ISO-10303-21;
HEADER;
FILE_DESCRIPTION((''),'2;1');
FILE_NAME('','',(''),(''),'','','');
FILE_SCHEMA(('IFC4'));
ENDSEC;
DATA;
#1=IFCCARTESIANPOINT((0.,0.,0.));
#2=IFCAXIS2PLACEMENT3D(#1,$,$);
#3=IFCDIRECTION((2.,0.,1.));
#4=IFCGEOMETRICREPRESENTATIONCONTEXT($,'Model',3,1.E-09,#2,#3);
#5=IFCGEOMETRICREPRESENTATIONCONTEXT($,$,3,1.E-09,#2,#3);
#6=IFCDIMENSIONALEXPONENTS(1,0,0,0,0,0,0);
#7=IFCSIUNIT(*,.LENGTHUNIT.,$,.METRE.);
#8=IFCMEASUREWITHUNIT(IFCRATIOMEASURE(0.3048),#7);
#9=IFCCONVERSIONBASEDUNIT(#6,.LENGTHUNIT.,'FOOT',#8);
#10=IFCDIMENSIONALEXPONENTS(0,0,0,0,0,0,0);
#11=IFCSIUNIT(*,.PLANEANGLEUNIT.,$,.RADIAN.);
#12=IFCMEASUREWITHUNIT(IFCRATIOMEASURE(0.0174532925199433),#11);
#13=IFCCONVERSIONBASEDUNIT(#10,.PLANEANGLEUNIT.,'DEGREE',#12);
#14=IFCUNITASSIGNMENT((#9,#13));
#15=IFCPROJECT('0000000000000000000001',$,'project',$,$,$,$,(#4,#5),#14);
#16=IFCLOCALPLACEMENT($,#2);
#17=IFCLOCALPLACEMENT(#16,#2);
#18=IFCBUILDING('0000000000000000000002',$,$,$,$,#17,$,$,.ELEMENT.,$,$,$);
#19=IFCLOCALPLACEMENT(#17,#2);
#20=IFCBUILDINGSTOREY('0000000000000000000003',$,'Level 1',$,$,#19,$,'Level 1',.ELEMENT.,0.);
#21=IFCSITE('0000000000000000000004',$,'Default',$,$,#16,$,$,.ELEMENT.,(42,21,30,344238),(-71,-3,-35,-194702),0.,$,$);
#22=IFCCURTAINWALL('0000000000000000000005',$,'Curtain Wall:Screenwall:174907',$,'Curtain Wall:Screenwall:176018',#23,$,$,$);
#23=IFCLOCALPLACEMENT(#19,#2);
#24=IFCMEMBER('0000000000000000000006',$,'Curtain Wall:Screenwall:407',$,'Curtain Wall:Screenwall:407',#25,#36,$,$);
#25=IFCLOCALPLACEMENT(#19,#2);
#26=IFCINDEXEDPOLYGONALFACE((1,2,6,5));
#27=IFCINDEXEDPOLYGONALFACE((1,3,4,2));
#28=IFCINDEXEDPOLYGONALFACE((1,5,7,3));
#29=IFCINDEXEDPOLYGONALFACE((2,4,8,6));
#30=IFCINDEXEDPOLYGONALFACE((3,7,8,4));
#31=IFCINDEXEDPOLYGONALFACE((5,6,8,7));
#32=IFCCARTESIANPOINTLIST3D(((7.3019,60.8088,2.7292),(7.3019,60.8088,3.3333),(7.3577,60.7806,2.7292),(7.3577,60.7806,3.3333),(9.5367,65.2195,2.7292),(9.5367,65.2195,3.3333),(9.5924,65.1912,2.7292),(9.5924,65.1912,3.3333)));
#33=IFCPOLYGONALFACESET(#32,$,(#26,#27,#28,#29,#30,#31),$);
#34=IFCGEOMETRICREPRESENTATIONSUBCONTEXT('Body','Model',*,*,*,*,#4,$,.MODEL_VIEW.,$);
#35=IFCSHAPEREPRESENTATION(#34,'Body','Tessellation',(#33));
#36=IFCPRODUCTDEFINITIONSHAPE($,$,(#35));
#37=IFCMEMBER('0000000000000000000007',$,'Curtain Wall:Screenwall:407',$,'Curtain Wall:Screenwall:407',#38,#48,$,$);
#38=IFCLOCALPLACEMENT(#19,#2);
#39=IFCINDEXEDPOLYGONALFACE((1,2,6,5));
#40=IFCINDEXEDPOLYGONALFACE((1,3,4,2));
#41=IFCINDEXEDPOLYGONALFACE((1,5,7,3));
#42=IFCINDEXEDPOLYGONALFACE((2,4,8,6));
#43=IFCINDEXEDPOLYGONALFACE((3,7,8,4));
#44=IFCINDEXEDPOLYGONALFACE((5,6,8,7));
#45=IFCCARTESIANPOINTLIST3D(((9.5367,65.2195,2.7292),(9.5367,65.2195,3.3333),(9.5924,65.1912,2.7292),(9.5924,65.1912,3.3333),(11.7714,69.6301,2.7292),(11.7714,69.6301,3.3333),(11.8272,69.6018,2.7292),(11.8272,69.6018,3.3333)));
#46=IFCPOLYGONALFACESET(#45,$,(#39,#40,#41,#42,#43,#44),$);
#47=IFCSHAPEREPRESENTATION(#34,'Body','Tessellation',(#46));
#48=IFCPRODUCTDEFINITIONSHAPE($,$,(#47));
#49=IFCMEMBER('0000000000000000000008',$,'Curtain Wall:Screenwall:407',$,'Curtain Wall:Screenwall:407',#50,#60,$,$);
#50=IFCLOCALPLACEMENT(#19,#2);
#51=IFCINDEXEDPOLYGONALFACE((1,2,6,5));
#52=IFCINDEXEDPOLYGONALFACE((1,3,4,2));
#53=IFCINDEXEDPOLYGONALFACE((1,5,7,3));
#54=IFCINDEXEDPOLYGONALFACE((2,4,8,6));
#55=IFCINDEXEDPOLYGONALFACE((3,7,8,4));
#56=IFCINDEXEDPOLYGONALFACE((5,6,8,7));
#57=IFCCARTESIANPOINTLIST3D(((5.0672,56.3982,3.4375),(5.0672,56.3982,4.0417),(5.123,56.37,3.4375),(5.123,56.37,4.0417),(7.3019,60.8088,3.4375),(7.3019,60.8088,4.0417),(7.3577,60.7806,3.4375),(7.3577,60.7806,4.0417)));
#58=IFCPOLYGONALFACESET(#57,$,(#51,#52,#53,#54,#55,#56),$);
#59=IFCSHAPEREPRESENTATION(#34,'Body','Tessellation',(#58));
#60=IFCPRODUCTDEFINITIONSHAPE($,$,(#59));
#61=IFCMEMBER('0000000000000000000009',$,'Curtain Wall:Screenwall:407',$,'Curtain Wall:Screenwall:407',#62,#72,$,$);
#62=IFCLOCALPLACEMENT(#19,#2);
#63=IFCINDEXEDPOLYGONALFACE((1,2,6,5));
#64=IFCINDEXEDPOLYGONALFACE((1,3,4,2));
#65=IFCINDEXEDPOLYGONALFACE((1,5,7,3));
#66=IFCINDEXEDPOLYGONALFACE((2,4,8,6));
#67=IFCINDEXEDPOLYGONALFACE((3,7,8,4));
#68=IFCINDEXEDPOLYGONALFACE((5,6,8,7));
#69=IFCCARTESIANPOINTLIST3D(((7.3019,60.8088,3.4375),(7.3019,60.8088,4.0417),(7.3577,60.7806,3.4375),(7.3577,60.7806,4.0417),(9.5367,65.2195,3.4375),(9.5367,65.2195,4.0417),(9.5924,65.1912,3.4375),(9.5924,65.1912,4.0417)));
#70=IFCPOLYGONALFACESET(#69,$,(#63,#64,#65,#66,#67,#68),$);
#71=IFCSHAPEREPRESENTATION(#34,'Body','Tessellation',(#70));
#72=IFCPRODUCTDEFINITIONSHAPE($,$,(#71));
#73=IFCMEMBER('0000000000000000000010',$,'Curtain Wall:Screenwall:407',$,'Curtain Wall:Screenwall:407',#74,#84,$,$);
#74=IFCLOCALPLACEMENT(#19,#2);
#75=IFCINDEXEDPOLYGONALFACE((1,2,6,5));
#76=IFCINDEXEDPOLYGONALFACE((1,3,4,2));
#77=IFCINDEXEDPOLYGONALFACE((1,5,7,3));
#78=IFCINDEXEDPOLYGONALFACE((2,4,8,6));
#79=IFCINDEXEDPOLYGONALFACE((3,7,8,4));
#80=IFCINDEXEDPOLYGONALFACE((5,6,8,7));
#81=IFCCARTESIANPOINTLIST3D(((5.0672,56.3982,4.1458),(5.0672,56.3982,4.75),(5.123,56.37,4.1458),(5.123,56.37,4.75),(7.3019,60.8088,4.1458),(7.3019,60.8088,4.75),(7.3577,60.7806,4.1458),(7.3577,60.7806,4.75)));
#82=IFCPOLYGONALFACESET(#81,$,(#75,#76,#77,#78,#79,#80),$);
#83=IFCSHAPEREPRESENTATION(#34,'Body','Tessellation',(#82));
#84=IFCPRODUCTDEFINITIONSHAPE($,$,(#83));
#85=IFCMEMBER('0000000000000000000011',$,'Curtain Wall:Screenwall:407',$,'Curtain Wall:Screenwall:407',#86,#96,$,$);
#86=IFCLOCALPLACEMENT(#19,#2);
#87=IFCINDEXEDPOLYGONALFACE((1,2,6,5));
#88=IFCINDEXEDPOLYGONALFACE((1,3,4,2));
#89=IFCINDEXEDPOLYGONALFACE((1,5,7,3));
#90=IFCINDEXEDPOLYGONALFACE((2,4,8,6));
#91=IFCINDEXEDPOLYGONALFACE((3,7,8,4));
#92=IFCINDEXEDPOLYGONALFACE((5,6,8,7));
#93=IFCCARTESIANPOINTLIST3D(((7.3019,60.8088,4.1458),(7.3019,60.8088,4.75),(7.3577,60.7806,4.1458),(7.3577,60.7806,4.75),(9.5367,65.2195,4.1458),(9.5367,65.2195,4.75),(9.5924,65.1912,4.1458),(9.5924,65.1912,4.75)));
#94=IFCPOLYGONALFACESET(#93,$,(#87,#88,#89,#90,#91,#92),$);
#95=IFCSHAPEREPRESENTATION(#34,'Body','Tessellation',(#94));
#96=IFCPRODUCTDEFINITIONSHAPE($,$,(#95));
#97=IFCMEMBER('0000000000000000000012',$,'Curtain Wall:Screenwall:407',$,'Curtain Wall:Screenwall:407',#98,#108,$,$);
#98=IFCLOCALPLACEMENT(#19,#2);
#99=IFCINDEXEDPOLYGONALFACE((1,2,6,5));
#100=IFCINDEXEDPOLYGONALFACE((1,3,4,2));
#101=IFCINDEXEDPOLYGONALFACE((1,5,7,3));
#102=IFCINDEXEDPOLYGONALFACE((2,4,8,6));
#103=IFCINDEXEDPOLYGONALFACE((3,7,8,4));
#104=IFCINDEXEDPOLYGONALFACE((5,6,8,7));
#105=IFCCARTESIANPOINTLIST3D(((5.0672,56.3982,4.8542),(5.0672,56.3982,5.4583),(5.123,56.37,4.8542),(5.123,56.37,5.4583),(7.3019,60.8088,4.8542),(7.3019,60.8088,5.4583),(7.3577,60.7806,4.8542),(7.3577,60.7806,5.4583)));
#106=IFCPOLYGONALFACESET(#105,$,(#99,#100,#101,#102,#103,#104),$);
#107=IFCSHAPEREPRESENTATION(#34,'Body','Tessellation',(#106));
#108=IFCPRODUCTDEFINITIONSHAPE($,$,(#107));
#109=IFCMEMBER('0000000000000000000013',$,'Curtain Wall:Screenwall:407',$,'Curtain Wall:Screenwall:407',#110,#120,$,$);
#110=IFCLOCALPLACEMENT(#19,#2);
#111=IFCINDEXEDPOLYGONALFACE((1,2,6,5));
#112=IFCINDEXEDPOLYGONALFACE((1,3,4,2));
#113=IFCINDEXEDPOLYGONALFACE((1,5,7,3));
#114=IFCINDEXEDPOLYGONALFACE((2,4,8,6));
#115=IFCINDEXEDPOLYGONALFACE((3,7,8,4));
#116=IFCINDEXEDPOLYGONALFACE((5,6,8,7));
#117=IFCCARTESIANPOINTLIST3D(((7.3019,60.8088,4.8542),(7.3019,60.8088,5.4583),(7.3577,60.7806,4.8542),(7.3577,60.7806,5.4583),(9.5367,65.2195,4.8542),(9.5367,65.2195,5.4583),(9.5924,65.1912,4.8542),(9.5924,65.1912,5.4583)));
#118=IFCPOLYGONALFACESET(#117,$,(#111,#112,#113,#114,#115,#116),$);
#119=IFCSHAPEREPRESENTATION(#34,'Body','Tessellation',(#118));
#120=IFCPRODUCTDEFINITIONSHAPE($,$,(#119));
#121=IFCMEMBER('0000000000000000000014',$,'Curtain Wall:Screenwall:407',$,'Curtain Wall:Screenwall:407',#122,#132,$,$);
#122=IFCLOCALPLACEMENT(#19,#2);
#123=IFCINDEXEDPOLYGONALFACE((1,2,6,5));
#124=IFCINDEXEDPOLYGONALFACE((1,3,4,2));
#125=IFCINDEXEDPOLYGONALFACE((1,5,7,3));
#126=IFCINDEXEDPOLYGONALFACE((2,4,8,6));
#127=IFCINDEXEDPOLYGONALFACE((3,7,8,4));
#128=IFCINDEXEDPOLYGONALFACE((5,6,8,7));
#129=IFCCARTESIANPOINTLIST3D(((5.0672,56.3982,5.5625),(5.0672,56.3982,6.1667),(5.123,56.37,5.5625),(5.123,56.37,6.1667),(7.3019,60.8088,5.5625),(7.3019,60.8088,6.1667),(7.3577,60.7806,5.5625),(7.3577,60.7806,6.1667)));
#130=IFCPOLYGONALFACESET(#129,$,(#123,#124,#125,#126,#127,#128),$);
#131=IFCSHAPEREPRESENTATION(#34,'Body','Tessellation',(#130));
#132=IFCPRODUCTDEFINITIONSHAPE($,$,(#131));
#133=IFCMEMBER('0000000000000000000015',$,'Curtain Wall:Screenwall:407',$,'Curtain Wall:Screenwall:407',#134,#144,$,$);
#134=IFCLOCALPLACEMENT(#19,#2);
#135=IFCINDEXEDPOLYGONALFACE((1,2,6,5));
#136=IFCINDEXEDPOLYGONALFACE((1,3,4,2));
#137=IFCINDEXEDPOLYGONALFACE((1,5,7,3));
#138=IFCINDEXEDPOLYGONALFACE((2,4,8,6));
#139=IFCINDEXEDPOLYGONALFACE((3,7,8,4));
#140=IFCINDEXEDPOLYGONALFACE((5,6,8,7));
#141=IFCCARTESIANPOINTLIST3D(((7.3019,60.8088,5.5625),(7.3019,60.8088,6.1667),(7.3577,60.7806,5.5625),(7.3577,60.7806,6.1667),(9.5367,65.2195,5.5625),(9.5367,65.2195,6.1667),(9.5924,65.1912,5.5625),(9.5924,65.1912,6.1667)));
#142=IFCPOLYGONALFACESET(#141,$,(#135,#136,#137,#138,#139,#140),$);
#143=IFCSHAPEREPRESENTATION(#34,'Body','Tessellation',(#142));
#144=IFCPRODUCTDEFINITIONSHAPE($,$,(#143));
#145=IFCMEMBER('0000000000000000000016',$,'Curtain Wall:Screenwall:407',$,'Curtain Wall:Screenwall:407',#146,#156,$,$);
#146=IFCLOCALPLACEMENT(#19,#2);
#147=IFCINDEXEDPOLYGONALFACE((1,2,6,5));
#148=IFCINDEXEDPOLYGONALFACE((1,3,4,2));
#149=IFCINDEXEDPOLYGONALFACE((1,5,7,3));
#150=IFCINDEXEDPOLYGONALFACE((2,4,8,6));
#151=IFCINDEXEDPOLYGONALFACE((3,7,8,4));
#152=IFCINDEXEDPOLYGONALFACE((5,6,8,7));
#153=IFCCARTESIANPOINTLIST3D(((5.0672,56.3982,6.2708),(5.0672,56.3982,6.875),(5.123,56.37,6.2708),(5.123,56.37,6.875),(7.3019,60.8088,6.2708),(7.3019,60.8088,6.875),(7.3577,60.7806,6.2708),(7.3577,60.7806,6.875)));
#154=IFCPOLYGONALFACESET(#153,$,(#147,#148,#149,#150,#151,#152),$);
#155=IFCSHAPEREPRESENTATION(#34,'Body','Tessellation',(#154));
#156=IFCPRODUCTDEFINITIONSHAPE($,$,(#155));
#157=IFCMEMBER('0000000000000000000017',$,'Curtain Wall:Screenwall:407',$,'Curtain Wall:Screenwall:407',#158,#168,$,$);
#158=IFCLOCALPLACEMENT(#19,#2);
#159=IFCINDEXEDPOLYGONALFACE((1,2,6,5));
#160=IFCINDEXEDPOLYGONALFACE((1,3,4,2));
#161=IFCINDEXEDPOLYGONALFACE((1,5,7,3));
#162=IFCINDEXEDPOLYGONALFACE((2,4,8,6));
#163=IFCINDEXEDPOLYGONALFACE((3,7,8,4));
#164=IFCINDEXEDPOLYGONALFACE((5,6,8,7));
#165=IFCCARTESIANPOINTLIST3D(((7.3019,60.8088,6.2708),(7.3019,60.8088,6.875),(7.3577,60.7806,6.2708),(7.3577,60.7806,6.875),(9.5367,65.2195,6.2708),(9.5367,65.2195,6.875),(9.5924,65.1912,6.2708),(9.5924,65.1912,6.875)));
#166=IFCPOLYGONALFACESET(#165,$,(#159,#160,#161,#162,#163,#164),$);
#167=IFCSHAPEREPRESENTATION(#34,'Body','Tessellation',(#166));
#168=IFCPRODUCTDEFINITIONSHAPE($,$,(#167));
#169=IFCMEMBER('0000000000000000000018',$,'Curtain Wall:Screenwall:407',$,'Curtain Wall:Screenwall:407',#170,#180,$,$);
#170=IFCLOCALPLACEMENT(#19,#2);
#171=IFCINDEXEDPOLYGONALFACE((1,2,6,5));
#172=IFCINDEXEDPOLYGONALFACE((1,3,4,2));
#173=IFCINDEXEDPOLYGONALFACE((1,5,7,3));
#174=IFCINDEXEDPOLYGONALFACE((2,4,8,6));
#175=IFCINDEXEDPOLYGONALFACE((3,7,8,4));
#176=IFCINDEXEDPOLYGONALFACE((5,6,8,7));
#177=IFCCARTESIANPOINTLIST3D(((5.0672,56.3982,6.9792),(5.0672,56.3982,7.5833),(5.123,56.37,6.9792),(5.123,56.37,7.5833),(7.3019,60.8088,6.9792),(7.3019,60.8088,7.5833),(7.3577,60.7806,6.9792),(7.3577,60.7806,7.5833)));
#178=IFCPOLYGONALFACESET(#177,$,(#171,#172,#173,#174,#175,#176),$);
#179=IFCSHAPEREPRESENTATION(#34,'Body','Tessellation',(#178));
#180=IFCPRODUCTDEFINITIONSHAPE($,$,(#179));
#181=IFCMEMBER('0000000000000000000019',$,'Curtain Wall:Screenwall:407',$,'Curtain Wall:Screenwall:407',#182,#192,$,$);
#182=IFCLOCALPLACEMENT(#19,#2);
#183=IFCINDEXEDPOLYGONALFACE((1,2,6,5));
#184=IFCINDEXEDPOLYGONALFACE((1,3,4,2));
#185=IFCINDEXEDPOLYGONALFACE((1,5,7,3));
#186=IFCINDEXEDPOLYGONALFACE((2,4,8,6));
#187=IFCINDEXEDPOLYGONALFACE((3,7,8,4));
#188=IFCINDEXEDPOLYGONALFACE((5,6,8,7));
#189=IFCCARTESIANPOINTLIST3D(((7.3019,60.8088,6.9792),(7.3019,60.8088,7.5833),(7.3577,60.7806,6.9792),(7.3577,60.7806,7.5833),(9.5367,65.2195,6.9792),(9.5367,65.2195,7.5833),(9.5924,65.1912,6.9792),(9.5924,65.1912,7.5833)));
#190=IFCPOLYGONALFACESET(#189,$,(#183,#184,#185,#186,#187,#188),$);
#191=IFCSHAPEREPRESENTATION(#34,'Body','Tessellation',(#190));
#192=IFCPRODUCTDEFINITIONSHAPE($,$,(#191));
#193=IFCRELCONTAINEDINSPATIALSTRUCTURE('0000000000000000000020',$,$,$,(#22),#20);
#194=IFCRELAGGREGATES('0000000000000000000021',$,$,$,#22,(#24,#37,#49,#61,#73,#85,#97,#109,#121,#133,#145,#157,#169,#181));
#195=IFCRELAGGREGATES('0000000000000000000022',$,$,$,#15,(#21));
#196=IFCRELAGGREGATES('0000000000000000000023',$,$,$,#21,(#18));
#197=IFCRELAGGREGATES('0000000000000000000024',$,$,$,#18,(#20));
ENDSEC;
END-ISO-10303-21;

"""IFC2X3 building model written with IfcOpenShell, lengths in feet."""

from ifc_helpers import new_model, entity, si_unit, converted_unit, direction, frame, frame_2d, origin, place, context, subcontext, project, spatial, rectangle, extrude, element, aggregate, save


model = new_model("IFC2X3")

# Units and contexts
model_context = context("Model", 3, precision=1e-09, world=origin(), true_north=direction((2.0, 0.0, 1.0)))
context_of_model = context(None, 3, precision=1e-09, world=origin(), true_north=direction((2.0, 0.0, 1.0)))
body_context = subcontext(model_context, "Body", "Model", "MODEL_VIEW")
ifc_project = project(units=[converted_unit("LENGTHUNIT", "FOOT", entity("IfcRatioMeasure", 0.3048), si_unit("LENGTHUNIT", "METRE"), dimensions=[1, 0, 0, 0, 0, 0, 0]), converted_unit("PLANEANGLEUNIT", "DEGREE", entity("IfcRatioMeasure", 0.0174532925199433), si_unit("PLANEANGLEUNIT", "RADIAN"), dimensions=[0, 0, 0, 0, 0, 0, 0])], contexts=[model_context, context_of_model])

# Site, building, storey
site_placement = place(None, origin())
site = spatial("IfcSite", under=ifc_project, at=site_placement, Name="Default", CompositionType="ELEMENT", RefLatitude=(42, 21, 30, 344238), RefLongitude=(-71, -3, -35, -194702), RefElevation=0.0)
building_placement = place(site_placement, origin())
building = spatial("IfcBuilding", under=site, at=building_placement, CompositionType="ELEMENT")
storey_placement = place(building_placement, origin())
storey = spatial("IfcBuildingStorey", under=building, at=storey_placement, Name="Level 1", LongName="Level 1", CompositionType="ELEMENT", Elevation=0.0)

# Curtain wall, members
curtain_wall_placement = place(storey_placement, origin())
curtain_wall = element("IfcCurtainWall", 1, at=curtain_wall_placement, inside=storey, Name="Curtain Wall:Screenwall:174907", ObjectType="Curtain Wall:Screenwall:176018")
member_1_placement = place(curtain_wall_placement, frame((7.3019, 60.7806, 2.7292)))
member_1 = element("IfcMember", 2, at=member_1_placement, Name="Curtain Wall:Screenwall:407", ObjectType="Curtain Wall:Screenwall:407", context=body_context, shape_type="SweptSolid", body=[
    extrude(rectangle(XDim=4.9444, YDim=0.0625, at=frame_2d((0.0, 0.0), x_axis=(1.0, 0.0))), frame((1.1452, 2.2194, 0.0), z_axis=(0.0, 0.0, 1.0), x_axis=(-0.451968, -0.892034, 0.0)), (0.0, 0.0, 1.0), 0.6042),
])
member_2_placement = place(curtain_wall_placement, frame((9.5367, 65.1912, 2.7292)))
member_2 = element("IfcMember", 3, at=member_2_placement, Name="Curtain Wall:Screenwall:407", ObjectType="Curtain Wall:Screenwall:407", context=body_context, shape_type="SweptSolid", body=[
    extrude(rectangle(XDim=4.9444, YDim=0.0625, at=frame_2d((0.0, 0.0), x_axis=(1.0, 0.0))), frame((1.1452, 2.2194, 0.0), z_axis=(0.0, 0.0, 1.0), x_axis=(-0.451968, -0.892034, 0.0)), (0.0, 0.0, 1.0), 0.6042),
])
member_3_placement = place(curtain_wall_placement, frame((5.0672, 56.37, 3.4375)))
member_3 = element("IfcMember", 4, at=member_3_placement, Name="Curtain Wall:Screenwall:407", ObjectType="Curtain Wall:Screenwall:407", context=body_context, shape_type="SweptSolid", body=[
    extrude(rectangle(XDim=4.9444, YDim=0.0625, at=frame_2d((0.0, 0.0), x_axis=(1.0, 0.0))), frame((1.1452, 2.2194, 0.0), z_axis=(0.0, 0.0, 1.0), x_axis=(-0.451968, -0.892034, 0.0)), (0.0, 0.0, 1.0), 0.6042),
])
member_4_placement = place(curtain_wall_placement, frame((7.3019, 60.7806, 3.4375)))
member_4 = element("IfcMember", 5, at=member_4_placement, Name="Curtain Wall:Screenwall:407", ObjectType="Curtain Wall:Screenwall:407", context=body_context, shape_type="SweptSolid", body=[
    extrude(rectangle(XDim=4.9444, YDim=0.0625, at=frame_2d((0.0, 0.0), x_axis=(1.0, 0.0))), frame((1.1452, 2.2194, 0.0), z_axis=(0.0, 0.0, 1.0), x_axis=(-0.451968, -0.892034, 0.0)), (0.0, 0.0, 1.0), 0.6042),
])
member_5_placement = place(curtain_wall_placement, frame((5.0672, 56.37, 4.1458)))
member_5 = element("IfcMember", 6, at=member_5_placement, Name="Curtain Wall:Screenwall:407", ObjectType="Curtain Wall:Screenwall:407", context=body_context, shape_type="SweptSolid", body=[
    extrude(rectangle(XDim=4.9444, YDim=0.0625, at=frame_2d((0.0, 0.0), x_axis=(1.0, 0.0))), frame((1.1452, 2.2194, 0.0), z_axis=(0.0, 0.0, 1.0), x_axis=(-0.451968, -0.892034, 0.0)), (0.0, 0.0, 1.0), 0.6042),
])
member_6_placement = place(curtain_wall_placement, frame((7.3019, 60.7806, 4.1458)))
member_6 = element("IfcMember", 7, at=member_6_placement, Name="Curtain Wall:Screenwall:407", ObjectType="Curtain Wall:Screenwall:407", context=body_context, shape_type="SweptSolid", body=[
    extrude(rectangle(XDim=4.9444, YDim=0.0625, at=frame_2d((0.0, 0.0), x_axis=(1.0, 0.0))), frame((1.1452, 2.2194, 0.0), z_axis=(0.0, 0.0, 1.0), x_axis=(-0.451968, -0.892034, 0.0)), (0.0, 0.0, 1.0), 0.6042),
])
member_7_placement = place(curtain_wall_placement, frame((5.0672, 56.37, 4.8542)))
member_7 = element("IfcMember", 8, at=member_7_placement, Name="Curtain Wall:Screenwall:407", ObjectType="Curtain Wall:Screenwall:407", context=body_context, shape_type="SweptSolid", body=[
    extrude(rectangle(XDim=4.9444, YDim=0.0625, at=frame_2d((0.0, 0.0), x_axis=(1.0, 0.0))), frame((1.1452, 2.2194, 0.0), z_axis=(0.0, 0.0, 1.0), x_axis=(-0.451968, -0.892034, 0.0)), (0.0, 0.0, 1.0), 0.6042),
])
member_8_placement = place(curtain_wall_placement, frame((7.3019, 60.7806, 4.8542)))
member_8 = element("IfcMember", 9, at=member_8_placement, Name="Curtain Wall:Screenwall:407", ObjectType="Curtain Wall:Screenwall:407", context=body_context, shape_type="SweptSolid", body=[
    extrude(rectangle(XDim=4.9444, YDim=0.0625, at=frame_2d((0.0, 0.0), x_axis=(1.0, 0.0))), frame((1.1452, 2.2194, 0.0), z_axis=(0.0, 0.0, 1.0), x_axis=(-0.451968, -0.892034, 0.0)), (0.0, 0.0, 1.0), 0.6042),
])
member_9_placement = place(curtain_wall_placement, frame((5.0672, 56.37, 5.5625)))
member_9 = element("IfcMember", 10, at=member_9_placement, Name="Curtain Wall:Screenwall:407", ObjectType="Curtain Wall:Screenwall:407", context=body_context, shape_type="SweptSolid", body=[
    extrude(rectangle(XDim=4.9444, YDim=0.0625, at=frame_2d((0.0, 0.0), x_axis=(1.0, 0.0))), frame((1.1452, 2.2194, 0.0), z_axis=(0.0, 0.0, 1.0), x_axis=(-0.451968, -0.892034, 0.0)), (0.0, 0.0, 1.0), 0.6042),
])
member_10_placement = place(curtain_wall_placement, frame((7.3019, 60.7806, 5.5625)))
member_10 = element("IfcMember", 11, at=member_10_placement, Name="Curtain Wall:Screenwall:407", ObjectType="Curtain Wall:Screenwall:407", context=body_context, shape_type="SweptSolid", body=[
    extrude(rectangle(XDim=4.9444, YDim=0.0625, at=frame_2d((0.0, 0.0), x_axis=(1.0, 0.0))), frame((1.1452, 2.2194, 0.0), z_axis=(0.0, 0.0, 1.0), x_axis=(-0.451968, -0.892034, 0.0)), (0.0, 0.0, 1.0), 0.6042),
])
member_11_placement = place(curtain_wall_placement, frame((5.0672, 56.37, 6.2708)))
member_11 = element("IfcMember", 12, at=member_11_placement, Name="Curtain Wall:Screenwall:407", ObjectType="Curtain Wall:Screenwall:407", context=body_context, shape_type="SweptSolid", body=[
    extrude(rectangle(XDim=4.9444, YDim=0.0625, at=frame_2d((0.0, 0.0), x_axis=(1.0, 0.0))), frame((1.1452, 2.2194, 0.0), z_axis=(0.0, 0.0, 1.0), x_axis=(-0.451968, -0.892034, 0.0)), (0.0, 0.0, 1.0), 0.6042),
])
member_12_placement = place(curtain_wall_placement, frame((7.3019, 60.7806, 6.2708)))
member_12 = element("IfcMember", 13, at=member_12_placement, Name="Curtain Wall:Screenwall:407", ObjectType="Curtain Wall:Screenwall:407", context=body_context, shape_type="SweptSolid", body=[
    extrude(rectangle(XDim=4.9444, YDim=0.0625, at=frame_2d((0.0, 0.0), x_axis=(1.0, 0.0))), frame((1.1452, 2.2194, 0.0), z_axis=(0.0, 0.0, 1.0), x_axis=(-0.451968, -0.892034, 0.0)), (0.0, 0.0, 1.0), 0.6042),
])
member_13_placement = place(curtain_wall_placement, frame((5.0672, 56.37, 6.9792)))
member_13 = element("IfcMember", 14, at=member_13_placement, Name="Curtain Wall:Screenwall:407", ObjectType="Curtain Wall:Screenwall:407", context=body_context, shape_type="SweptSolid", body=[
    extrude(rectangle(XDim=4.9444, YDim=0.0625, at=frame_2d((0.0, 0.0), x_axis=(1.0, 0.0))), frame((1.1452, 2.2194, 0.0), z_axis=(0.0, 0.0, 1.0), x_axis=(-0.451968, -0.892034, 0.0)), (0.0, 0.0, 1.0), 0.6042),
])
member_14_placement = place(curtain_wall_placement, frame((7.3019, 60.7806, 6.9792)))
member_14 = element("IfcMember", 15, at=member_14_placement, Name="Curtain Wall:Screenwall:407", ObjectType="Curtain Wall:Screenwall:407", context=body_context, shape_type="SweptSolid", body=[
    extrude(rectangle(XDim=4.9444, YDim=0.0625, at=frame_2d((0.0, 0.0), x_axis=(1.0, 0.0))), frame((1.1452, 2.2194, 0.0), z_axis=(0.0, 0.0, 1.0), x_axis=(-0.451968, -0.892034, 0.0)), (0.0, 0.0, 1.0), 0.6042),
])
aggregate(curtain_wall, [member_1, member_2, member_3, member_4, member_5, member_6, member_7, member_8, member_9, member_10, member_11, member_12, member_13, member_14])

save(model, "model.ifc")
